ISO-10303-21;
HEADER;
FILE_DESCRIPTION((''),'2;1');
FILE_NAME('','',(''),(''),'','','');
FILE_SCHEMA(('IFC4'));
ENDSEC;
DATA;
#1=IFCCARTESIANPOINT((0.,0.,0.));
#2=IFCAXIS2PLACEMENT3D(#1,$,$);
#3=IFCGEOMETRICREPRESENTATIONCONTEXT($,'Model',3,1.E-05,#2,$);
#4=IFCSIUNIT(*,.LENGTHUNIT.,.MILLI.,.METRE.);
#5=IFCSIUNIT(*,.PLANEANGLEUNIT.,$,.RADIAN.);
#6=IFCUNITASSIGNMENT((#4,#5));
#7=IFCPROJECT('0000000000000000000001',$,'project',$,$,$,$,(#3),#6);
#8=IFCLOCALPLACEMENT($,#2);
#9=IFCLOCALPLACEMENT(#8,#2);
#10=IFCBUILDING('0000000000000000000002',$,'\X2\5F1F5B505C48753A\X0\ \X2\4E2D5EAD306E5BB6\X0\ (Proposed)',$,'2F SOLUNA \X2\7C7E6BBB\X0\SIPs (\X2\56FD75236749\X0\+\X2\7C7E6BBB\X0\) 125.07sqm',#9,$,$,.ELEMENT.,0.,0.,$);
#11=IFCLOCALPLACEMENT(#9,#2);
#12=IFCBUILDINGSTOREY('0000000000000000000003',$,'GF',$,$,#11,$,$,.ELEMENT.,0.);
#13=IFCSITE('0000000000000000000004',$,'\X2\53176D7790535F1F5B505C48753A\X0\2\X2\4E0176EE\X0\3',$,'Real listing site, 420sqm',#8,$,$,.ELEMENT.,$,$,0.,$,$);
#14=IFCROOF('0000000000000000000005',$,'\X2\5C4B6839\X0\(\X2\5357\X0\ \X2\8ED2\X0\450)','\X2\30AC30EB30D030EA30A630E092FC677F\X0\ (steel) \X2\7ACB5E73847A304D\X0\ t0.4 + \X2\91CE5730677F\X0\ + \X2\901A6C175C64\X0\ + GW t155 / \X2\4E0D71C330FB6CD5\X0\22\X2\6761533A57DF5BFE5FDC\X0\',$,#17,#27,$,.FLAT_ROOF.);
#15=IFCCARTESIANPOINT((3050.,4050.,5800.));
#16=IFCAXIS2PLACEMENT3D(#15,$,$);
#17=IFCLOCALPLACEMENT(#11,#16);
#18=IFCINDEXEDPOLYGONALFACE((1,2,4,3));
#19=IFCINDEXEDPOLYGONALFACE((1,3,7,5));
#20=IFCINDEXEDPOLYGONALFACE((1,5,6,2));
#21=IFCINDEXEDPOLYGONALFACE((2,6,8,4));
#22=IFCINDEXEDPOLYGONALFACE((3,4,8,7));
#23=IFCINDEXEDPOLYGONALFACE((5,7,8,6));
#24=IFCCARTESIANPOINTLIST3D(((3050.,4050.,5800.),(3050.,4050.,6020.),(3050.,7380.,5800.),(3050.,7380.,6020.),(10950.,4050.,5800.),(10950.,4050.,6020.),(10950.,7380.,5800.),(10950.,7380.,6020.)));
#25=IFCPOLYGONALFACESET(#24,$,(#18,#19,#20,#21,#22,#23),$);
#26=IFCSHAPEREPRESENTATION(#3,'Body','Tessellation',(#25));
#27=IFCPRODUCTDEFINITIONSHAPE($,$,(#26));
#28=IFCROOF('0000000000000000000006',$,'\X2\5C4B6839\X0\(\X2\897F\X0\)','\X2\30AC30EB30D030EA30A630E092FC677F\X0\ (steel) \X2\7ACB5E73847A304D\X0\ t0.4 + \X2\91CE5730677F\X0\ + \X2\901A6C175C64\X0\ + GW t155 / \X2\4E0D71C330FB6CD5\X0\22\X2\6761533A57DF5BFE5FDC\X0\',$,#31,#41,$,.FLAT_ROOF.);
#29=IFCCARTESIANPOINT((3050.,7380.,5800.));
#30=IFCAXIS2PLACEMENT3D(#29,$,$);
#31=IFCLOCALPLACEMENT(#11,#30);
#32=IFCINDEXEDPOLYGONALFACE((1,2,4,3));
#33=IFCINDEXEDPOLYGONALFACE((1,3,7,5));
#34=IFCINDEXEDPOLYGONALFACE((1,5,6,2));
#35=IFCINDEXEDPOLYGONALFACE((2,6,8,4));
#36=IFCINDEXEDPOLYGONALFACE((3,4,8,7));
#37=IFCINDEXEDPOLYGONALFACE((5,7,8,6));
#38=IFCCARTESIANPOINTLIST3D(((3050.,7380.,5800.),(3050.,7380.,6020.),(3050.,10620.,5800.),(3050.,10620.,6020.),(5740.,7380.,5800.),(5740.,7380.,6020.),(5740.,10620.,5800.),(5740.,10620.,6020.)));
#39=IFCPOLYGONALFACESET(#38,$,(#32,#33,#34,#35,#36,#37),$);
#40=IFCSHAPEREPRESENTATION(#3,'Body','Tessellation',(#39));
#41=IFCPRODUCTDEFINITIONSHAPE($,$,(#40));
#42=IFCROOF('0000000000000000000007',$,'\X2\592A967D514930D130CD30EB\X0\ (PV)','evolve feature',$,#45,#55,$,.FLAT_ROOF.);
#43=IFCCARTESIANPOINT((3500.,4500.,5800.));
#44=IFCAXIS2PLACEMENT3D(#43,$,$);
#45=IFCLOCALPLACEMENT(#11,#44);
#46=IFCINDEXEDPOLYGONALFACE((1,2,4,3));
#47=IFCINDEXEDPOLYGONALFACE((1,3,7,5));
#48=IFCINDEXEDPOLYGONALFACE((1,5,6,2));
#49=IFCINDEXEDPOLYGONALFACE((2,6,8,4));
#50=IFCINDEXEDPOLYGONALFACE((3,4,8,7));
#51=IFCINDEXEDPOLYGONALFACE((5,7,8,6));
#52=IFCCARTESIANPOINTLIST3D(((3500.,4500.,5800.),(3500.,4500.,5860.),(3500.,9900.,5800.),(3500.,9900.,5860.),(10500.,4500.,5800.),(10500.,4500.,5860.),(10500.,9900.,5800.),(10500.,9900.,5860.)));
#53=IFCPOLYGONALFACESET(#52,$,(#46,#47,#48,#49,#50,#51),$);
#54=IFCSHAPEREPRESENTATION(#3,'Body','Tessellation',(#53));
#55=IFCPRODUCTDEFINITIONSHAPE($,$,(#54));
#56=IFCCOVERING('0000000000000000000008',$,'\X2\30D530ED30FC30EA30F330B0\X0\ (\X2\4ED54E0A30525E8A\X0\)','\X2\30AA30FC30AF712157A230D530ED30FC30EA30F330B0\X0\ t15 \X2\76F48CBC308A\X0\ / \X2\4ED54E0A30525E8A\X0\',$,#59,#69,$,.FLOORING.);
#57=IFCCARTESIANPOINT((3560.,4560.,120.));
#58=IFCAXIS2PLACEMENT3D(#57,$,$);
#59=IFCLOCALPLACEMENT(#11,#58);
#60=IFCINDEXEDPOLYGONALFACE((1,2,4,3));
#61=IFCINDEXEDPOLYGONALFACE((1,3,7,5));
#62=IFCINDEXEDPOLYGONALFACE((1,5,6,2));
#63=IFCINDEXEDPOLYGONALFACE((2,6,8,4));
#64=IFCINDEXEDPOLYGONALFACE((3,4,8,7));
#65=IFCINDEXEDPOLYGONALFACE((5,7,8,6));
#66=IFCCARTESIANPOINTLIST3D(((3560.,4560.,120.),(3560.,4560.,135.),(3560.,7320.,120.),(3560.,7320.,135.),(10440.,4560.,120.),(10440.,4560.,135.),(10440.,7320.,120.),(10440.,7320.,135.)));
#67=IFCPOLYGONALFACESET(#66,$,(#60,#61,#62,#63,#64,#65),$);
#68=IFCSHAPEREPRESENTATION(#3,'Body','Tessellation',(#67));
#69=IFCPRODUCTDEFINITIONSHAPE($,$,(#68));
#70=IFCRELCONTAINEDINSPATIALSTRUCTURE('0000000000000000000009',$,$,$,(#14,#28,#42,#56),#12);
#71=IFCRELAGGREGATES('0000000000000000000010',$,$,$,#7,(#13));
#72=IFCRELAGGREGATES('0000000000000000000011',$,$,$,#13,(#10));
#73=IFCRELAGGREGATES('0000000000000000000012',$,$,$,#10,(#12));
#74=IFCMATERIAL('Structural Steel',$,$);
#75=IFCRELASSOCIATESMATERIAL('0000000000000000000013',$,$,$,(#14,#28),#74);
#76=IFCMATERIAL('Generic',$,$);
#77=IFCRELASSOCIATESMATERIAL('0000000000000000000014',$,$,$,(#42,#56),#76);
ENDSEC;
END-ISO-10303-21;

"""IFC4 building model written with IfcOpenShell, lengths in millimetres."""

from ifc_helpers import new_model, si_unit, frame, frame_2d, origin, place, context, project, spatial, rectangle, extrude, material, element, save


model = new_model("IFC4")

# Units and contexts
model_context = context("Model", 3, precision=1e-05, world=origin())
ifc_project = project(units=[si_unit("LENGTHUNIT", "METRE", prefix="MILLI"), si_unit("PLANEANGLEUNIT", "RADIAN")], contexts=[model_context])

# Site, building, storey
site_placement = place(None, origin())
site = spatial("IfcSite", under=ifc_project, at=site_placement, Name="北海道弟子屈町2丁目3", ObjectType="Real listing site, 420sqm", CompositionType="ELEMENT", RefElevation=0.0)
building_placement = place(site_placement, origin())
building = spatial("IfcBuilding", under=site, at=building_placement, Name="弟子屈町 中庭の家 (Proposed)", ObjectType="2F SOLUNA 籾殻SIPs (国産杉+籾殻) 125.07sqm", CompositionType="ELEMENT", ElevationOfRefHeight=0.0, ElevationOfTerrain=0.0)
storey_placement = place(building_placement, origin())
storey = spatial("IfcBuildingStorey", under=building, at=storey_placement, Name="GF", CompositionType="ELEMENT", Elevation=0.0)

# Shared definitions
ifc_material_1 = material(Name="Generic")

# Roofs
ifc_material_2 = material(Name="Structural Steel")
roof_1_placement = place(storey_placement, frame((3050.0, 4050.0, 5800.0)))
element("IfcRoof", 1, at=roof_1_placement, inside=storey, material=ifc_material_2, Name="屋根(南 軒450)", Description="ガルバリウム鋼板 (steel) 立平葺き t0.4 + 野地板 + 通気層 + GW t155 / 不燃・法22条区域対応", PredefinedType="FLAT_ROOF", context=model_context, shape_type="SweptSolid", body=[
    extrude(rectangle(XDim=7900.0, YDim=3330.0, at=frame_2d((3950.0, 1665.0))), frame((3050.0, 4050.0, 5800.0)), (0.0, 0.0, 1.0), 220.0),
])
roof_2_placement = place(storey_placement, frame((3050.0, 7380.0, 5800.0)))
element("IfcRoof", 2, at=roof_2_placement, inside=storey, material=ifc_material_2, Name="屋根(西)", Description="ガルバリウム鋼板 (steel) 立平葺き t0.4 + 野地板 + 通気層 + GW t155 / 不燃・法22条区域対応", PredefinedType="FLAT_ROOF", context=model_context, shape_type="SweptSolid", body=[
    extrude(rectangle(XDim=2690.0, YDim=3240.0, at=frame_2d((1345.0, 1620.0))), frame((3050.0, 7380.0, 5800.0)), (0.0, 0.0, 1.0), 220.0),
])
roof_3_placement = place(storey_placement, frame((3500.0, 4500.0, 5800.0)))
element("IfcRoof", 3, at=roof_3_placement, inside=storey, material=ifc_material_1, Name="太陽光パネル (PV)", Description="evolve feature", PredefinedType="FLAT_ROOF", context=model_context, shape_type="SweptSolid", body=[
    extrude(rectangle(XDim=7000.0, YDim=5400.0, at=frame_2d((3500.0, 2700.0))), frame((3500.0, 4500.0, 5800.0)), (0.0, 0.0, 1.0), 60.0),
])

# Covering
covering_placement = place(storey_placement, frame((3560.0, 4560.0, 120.0)))
element("IfcCovering", 4, at=covering_placement, inside=storey, material=ifc_material_1, Name="フローリング (仕上げ床)", Description="オーク無垢フローリング t15 直貼り / 仕上げ床", PredefinedType="FLOORING", context=model_context, shape_type="SweptSolid", body=[
    extrude(rectangle(XDim=6880.0, YDim=2760.0, at=frame_2d((3440.0, 1380.0))), frame((3560.0, 4560.0, 120.0)), (0.0, 0.0, 1.0), 15.0),
])

save(model, "model.ifc")
